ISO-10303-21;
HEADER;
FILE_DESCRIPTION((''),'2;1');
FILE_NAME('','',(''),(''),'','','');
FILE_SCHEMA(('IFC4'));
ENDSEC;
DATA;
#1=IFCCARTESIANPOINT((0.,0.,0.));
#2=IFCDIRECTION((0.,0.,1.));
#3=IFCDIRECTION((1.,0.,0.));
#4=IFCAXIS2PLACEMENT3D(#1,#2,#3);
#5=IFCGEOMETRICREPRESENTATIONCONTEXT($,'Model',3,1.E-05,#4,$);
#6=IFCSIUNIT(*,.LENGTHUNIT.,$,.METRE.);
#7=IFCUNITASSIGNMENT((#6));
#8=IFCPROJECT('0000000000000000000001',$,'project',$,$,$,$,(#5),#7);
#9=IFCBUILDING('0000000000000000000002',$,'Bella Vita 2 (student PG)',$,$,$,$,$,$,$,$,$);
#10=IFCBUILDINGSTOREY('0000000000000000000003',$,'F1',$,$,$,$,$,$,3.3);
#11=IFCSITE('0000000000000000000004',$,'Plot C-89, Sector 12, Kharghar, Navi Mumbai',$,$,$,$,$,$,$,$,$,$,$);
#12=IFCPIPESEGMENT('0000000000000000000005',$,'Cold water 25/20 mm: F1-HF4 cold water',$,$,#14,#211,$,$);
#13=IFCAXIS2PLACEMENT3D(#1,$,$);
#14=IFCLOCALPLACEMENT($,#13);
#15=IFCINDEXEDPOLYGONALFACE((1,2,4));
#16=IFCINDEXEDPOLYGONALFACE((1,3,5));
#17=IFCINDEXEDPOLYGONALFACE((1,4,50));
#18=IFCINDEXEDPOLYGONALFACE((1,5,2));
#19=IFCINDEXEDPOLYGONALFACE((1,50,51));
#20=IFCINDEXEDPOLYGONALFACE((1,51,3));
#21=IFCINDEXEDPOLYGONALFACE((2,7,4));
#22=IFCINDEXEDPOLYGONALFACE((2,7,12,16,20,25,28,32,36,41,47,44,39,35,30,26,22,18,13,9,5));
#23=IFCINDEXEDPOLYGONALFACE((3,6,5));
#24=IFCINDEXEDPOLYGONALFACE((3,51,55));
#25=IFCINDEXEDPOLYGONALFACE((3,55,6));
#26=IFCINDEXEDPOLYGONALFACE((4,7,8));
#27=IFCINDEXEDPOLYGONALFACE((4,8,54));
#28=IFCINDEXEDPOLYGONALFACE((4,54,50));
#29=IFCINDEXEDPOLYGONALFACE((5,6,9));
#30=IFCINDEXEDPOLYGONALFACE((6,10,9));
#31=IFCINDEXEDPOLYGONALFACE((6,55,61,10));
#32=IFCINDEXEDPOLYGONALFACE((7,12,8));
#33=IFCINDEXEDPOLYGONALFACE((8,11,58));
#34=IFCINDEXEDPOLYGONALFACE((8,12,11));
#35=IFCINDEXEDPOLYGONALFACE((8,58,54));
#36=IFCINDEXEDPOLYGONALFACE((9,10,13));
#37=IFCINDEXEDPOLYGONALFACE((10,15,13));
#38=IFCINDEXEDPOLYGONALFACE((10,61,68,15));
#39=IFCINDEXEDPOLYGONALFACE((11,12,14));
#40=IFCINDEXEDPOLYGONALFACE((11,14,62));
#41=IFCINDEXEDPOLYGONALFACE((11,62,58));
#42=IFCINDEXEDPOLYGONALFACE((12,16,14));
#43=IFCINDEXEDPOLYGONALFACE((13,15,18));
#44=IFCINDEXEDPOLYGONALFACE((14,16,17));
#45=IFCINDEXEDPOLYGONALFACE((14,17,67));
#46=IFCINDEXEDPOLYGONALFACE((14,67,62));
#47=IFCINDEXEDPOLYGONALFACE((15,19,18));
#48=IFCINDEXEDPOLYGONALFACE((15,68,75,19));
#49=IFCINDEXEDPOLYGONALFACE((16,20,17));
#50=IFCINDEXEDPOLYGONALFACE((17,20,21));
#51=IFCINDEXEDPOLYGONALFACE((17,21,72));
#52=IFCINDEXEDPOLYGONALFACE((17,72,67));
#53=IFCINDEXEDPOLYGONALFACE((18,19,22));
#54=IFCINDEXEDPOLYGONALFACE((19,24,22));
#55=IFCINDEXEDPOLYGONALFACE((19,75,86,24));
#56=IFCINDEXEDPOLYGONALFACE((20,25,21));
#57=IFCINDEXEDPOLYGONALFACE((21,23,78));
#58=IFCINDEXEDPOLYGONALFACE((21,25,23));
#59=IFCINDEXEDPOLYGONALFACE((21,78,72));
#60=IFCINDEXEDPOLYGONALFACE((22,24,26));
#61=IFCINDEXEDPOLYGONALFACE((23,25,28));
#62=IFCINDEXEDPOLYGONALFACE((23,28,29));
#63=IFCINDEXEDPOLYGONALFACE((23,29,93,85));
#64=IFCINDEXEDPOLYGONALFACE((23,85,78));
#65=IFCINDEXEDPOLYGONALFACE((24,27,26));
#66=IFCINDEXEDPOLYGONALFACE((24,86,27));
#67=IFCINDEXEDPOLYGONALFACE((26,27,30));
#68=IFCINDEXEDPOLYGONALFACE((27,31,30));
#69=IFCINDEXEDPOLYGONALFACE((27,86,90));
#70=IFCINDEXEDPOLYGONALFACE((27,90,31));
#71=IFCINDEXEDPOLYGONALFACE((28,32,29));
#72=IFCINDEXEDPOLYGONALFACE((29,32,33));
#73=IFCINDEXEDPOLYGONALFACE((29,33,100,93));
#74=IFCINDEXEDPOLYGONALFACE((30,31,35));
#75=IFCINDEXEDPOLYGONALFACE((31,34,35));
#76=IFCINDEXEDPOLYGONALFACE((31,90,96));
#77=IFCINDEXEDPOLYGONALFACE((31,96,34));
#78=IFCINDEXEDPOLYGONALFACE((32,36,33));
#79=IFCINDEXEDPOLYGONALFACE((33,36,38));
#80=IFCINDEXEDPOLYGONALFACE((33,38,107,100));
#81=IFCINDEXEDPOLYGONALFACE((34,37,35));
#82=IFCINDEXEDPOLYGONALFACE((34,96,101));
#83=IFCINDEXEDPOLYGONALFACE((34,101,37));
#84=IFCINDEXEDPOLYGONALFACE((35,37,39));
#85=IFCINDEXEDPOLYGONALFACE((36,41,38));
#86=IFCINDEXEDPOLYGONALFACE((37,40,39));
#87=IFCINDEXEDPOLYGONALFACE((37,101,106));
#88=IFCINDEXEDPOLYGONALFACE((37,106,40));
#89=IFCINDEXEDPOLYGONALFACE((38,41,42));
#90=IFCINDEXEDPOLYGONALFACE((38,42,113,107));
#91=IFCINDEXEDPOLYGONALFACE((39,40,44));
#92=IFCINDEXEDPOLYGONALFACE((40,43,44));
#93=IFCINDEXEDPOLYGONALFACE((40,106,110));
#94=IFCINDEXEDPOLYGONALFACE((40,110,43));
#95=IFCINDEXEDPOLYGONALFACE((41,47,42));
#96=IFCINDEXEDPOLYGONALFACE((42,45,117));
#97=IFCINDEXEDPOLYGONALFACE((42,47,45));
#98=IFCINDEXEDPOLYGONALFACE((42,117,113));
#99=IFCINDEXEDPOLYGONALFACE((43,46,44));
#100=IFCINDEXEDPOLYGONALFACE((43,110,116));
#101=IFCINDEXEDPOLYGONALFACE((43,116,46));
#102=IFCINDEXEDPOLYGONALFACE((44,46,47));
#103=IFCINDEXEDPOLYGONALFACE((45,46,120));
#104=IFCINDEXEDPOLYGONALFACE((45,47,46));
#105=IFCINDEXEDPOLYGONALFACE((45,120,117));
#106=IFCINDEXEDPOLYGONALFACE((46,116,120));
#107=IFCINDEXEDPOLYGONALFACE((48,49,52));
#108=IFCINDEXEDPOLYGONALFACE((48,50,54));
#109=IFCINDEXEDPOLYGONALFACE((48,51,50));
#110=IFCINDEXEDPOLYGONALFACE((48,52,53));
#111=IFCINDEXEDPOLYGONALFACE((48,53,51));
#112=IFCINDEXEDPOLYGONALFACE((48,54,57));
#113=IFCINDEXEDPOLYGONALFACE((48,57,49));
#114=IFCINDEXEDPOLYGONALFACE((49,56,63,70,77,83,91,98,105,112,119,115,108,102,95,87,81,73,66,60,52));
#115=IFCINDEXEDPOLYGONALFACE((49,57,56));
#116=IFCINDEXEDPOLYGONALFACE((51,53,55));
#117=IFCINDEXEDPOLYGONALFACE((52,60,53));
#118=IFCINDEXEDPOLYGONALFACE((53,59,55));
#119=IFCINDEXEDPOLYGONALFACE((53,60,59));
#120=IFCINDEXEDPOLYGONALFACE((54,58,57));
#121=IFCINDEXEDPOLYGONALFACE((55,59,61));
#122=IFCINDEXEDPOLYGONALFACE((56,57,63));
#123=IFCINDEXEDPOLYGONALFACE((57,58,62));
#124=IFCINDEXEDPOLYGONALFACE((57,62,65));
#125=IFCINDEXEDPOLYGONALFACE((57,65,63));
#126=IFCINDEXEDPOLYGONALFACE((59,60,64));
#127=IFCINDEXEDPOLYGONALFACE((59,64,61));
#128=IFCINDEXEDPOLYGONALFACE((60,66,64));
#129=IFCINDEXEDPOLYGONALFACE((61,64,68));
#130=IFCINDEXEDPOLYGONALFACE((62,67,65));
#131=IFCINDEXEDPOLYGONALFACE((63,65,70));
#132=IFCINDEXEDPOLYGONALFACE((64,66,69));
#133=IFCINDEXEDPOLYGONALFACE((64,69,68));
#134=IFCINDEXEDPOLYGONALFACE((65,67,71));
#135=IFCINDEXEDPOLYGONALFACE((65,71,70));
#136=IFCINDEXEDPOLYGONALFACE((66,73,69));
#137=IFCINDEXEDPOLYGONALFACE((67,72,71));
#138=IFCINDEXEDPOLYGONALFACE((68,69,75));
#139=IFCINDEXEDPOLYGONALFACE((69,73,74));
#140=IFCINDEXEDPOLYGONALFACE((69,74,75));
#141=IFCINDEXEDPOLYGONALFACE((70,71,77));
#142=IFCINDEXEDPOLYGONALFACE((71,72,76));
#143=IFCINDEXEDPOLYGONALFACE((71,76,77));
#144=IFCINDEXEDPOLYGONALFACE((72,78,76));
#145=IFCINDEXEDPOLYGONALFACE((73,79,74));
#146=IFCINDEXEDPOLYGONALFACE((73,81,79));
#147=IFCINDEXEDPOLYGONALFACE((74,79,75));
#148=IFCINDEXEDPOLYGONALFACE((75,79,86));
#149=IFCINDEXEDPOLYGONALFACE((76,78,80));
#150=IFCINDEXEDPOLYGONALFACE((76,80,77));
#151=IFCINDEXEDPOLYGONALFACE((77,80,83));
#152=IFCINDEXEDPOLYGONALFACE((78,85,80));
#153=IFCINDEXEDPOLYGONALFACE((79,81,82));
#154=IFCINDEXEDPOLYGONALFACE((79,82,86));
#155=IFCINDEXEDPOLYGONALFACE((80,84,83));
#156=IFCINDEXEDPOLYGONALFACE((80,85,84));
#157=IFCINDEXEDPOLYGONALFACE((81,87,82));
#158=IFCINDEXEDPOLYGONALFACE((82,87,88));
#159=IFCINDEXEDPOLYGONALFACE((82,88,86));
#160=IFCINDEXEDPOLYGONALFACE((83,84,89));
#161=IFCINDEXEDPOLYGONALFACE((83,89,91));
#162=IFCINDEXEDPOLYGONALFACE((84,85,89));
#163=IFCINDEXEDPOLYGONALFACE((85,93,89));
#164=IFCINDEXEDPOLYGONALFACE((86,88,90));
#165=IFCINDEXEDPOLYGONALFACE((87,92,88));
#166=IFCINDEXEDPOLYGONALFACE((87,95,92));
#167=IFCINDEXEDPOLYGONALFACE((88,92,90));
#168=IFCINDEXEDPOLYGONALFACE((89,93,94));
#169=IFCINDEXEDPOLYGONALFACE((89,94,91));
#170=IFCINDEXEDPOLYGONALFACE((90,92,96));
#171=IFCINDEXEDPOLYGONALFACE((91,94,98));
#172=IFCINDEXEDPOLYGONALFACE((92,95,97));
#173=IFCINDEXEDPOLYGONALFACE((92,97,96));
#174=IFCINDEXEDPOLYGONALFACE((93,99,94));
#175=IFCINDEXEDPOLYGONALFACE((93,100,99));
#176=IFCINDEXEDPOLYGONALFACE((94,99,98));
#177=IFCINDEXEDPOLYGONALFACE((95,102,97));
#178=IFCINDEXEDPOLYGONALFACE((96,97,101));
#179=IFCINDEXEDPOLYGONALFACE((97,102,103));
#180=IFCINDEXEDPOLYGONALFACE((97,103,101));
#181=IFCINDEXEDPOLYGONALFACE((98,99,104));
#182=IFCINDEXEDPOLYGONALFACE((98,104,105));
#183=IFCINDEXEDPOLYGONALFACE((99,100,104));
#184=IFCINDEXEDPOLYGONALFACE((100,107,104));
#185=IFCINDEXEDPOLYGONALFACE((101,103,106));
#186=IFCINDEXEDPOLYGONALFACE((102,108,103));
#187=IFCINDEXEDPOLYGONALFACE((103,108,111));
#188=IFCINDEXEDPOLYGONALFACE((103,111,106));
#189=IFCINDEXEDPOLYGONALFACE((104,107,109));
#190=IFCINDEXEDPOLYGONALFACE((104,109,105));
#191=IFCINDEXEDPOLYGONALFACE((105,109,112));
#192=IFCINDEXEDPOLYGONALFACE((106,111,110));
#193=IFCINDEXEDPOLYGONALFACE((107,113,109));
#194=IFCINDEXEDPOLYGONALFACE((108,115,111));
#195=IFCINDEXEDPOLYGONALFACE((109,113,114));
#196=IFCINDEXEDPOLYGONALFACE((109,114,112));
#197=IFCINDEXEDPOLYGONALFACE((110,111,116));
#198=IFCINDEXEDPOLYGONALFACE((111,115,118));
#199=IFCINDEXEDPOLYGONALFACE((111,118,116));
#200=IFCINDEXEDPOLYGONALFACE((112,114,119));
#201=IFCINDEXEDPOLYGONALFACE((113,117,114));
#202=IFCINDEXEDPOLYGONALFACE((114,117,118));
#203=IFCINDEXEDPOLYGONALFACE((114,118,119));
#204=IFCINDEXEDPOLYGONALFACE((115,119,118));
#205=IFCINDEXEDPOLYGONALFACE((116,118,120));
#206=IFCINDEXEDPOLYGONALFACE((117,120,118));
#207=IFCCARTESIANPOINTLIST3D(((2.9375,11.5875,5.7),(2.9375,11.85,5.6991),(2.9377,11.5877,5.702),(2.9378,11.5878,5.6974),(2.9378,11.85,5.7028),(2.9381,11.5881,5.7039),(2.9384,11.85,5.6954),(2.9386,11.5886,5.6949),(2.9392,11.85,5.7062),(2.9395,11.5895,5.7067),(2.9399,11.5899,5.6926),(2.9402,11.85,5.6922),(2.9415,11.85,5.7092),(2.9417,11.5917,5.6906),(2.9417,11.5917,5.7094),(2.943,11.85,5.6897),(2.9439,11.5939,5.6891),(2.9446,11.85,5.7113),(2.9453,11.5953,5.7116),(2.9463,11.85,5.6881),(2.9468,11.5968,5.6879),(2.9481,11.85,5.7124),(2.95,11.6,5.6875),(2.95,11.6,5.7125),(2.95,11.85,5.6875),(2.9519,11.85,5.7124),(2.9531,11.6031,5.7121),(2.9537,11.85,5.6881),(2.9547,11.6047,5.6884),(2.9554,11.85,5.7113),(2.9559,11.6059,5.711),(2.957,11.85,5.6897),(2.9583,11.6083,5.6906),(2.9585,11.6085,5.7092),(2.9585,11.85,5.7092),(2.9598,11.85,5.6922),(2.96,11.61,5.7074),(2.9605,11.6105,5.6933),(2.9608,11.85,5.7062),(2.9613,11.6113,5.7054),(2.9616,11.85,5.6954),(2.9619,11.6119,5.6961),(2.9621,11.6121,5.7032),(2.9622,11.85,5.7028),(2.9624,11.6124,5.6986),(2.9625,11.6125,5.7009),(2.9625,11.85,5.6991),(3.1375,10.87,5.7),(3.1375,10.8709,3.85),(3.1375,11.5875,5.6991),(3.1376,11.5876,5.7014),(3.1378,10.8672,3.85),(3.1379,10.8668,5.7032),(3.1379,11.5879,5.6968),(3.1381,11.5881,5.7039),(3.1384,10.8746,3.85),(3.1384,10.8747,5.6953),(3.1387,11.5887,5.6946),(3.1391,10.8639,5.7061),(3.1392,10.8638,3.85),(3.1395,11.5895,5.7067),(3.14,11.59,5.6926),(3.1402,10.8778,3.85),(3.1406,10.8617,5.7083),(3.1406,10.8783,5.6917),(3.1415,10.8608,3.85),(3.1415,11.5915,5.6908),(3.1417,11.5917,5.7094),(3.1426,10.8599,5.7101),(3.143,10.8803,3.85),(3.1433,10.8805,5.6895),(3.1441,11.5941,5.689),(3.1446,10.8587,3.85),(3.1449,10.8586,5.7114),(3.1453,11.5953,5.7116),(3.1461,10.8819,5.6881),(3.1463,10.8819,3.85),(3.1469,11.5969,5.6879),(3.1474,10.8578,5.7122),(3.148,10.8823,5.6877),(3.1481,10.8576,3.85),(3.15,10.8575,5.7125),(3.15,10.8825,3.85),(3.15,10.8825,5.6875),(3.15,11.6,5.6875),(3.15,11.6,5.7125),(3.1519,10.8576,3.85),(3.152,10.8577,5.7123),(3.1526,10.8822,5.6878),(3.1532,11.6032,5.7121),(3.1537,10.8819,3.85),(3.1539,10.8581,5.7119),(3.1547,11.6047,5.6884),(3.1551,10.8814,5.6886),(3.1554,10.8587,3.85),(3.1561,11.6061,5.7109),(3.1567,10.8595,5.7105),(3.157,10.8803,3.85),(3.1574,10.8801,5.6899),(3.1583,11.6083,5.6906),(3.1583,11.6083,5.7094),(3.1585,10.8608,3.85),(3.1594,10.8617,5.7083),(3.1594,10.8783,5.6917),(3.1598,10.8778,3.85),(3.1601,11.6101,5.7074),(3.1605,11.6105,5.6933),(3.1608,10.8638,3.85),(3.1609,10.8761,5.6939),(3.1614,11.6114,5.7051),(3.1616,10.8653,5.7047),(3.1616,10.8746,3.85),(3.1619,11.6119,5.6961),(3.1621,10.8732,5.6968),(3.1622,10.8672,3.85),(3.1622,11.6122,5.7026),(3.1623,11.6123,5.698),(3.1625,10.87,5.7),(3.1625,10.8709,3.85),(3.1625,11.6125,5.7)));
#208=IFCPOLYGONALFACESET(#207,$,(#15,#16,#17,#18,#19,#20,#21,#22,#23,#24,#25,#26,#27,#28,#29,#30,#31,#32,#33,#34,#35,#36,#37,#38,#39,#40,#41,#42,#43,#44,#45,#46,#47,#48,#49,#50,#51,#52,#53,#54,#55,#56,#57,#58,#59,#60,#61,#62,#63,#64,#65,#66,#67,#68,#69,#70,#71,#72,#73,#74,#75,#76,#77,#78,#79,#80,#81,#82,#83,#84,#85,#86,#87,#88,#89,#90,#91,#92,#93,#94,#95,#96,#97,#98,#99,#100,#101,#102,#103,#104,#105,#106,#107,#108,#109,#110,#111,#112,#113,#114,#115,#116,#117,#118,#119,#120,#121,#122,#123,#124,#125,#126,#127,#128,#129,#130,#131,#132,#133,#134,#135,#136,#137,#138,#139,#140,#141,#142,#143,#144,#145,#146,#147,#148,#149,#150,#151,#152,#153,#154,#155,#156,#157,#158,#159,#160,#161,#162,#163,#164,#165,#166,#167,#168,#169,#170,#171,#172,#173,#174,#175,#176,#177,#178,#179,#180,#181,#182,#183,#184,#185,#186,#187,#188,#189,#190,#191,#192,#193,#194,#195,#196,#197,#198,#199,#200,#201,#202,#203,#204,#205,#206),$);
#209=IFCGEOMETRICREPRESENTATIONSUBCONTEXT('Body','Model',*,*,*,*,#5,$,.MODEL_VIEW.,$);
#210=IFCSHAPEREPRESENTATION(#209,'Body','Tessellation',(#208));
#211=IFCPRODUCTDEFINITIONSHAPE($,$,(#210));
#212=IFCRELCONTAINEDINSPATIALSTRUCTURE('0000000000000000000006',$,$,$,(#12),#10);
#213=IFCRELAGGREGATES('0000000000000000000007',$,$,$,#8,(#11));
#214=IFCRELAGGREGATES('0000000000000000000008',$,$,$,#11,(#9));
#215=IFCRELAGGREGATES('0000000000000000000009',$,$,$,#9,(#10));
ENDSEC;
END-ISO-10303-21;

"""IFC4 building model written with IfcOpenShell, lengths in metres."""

from ifc_helpers import new_model, entity, si_unit, origin, origin_with_axes, place, context, subcontext, project, spatial, element, save


model = new_model("IFC4")

# Units and contexts
model_context = context("Model", 3, precision=1e-05, world=origin_with_axes())
body_context = subcontext(model_context, "Body", "Model", "MODEL_VIEW")
ifc_project = project(units=[si_unit("LENGTHUNIT", "METRE")], contexts=[model_context])

# Site, building, storey
site = spatial("IfcSite", under=ifc_project, Name="Plot C-89, Sector 12, Kharghar, Navi Mumbai")
building = spatial("IfcBuilding", under=site, Name="Bella Vita 2 (student PG)")
storey = spatial("IfcBuildingStorey", under=building, Name="F1", Elevation=3.3)

# Pipe segment
pipe_segment_1_placement = place(None, origin())
element("IfcPipeSegment", 1, at=pipe_segment_1_placement, inside=storey, Name="Cold water 25/20 mm: F1-HF4 cold water", context=body_context, shape_type="AdvancedSweptSolid", body=[
    entity("IfcSweptDiskSolid", entity("IfcPolyline", [entity("IfcCartesianPoint", [2.95, 11.85, 5.7]), entity("IfcCartesianPoint", [2.95, 11.6, 5.7]), entity("IfcCartesianPoint", [3.15, 11.6, 5.7]), entity("IfcCartesianPoint", [3.15, 10.87, 5.7]), entity("IfcCartesianPoint", [3.15, 10.87, 3.85])]), 0.0125),
])

save(model, "model.ifc")
